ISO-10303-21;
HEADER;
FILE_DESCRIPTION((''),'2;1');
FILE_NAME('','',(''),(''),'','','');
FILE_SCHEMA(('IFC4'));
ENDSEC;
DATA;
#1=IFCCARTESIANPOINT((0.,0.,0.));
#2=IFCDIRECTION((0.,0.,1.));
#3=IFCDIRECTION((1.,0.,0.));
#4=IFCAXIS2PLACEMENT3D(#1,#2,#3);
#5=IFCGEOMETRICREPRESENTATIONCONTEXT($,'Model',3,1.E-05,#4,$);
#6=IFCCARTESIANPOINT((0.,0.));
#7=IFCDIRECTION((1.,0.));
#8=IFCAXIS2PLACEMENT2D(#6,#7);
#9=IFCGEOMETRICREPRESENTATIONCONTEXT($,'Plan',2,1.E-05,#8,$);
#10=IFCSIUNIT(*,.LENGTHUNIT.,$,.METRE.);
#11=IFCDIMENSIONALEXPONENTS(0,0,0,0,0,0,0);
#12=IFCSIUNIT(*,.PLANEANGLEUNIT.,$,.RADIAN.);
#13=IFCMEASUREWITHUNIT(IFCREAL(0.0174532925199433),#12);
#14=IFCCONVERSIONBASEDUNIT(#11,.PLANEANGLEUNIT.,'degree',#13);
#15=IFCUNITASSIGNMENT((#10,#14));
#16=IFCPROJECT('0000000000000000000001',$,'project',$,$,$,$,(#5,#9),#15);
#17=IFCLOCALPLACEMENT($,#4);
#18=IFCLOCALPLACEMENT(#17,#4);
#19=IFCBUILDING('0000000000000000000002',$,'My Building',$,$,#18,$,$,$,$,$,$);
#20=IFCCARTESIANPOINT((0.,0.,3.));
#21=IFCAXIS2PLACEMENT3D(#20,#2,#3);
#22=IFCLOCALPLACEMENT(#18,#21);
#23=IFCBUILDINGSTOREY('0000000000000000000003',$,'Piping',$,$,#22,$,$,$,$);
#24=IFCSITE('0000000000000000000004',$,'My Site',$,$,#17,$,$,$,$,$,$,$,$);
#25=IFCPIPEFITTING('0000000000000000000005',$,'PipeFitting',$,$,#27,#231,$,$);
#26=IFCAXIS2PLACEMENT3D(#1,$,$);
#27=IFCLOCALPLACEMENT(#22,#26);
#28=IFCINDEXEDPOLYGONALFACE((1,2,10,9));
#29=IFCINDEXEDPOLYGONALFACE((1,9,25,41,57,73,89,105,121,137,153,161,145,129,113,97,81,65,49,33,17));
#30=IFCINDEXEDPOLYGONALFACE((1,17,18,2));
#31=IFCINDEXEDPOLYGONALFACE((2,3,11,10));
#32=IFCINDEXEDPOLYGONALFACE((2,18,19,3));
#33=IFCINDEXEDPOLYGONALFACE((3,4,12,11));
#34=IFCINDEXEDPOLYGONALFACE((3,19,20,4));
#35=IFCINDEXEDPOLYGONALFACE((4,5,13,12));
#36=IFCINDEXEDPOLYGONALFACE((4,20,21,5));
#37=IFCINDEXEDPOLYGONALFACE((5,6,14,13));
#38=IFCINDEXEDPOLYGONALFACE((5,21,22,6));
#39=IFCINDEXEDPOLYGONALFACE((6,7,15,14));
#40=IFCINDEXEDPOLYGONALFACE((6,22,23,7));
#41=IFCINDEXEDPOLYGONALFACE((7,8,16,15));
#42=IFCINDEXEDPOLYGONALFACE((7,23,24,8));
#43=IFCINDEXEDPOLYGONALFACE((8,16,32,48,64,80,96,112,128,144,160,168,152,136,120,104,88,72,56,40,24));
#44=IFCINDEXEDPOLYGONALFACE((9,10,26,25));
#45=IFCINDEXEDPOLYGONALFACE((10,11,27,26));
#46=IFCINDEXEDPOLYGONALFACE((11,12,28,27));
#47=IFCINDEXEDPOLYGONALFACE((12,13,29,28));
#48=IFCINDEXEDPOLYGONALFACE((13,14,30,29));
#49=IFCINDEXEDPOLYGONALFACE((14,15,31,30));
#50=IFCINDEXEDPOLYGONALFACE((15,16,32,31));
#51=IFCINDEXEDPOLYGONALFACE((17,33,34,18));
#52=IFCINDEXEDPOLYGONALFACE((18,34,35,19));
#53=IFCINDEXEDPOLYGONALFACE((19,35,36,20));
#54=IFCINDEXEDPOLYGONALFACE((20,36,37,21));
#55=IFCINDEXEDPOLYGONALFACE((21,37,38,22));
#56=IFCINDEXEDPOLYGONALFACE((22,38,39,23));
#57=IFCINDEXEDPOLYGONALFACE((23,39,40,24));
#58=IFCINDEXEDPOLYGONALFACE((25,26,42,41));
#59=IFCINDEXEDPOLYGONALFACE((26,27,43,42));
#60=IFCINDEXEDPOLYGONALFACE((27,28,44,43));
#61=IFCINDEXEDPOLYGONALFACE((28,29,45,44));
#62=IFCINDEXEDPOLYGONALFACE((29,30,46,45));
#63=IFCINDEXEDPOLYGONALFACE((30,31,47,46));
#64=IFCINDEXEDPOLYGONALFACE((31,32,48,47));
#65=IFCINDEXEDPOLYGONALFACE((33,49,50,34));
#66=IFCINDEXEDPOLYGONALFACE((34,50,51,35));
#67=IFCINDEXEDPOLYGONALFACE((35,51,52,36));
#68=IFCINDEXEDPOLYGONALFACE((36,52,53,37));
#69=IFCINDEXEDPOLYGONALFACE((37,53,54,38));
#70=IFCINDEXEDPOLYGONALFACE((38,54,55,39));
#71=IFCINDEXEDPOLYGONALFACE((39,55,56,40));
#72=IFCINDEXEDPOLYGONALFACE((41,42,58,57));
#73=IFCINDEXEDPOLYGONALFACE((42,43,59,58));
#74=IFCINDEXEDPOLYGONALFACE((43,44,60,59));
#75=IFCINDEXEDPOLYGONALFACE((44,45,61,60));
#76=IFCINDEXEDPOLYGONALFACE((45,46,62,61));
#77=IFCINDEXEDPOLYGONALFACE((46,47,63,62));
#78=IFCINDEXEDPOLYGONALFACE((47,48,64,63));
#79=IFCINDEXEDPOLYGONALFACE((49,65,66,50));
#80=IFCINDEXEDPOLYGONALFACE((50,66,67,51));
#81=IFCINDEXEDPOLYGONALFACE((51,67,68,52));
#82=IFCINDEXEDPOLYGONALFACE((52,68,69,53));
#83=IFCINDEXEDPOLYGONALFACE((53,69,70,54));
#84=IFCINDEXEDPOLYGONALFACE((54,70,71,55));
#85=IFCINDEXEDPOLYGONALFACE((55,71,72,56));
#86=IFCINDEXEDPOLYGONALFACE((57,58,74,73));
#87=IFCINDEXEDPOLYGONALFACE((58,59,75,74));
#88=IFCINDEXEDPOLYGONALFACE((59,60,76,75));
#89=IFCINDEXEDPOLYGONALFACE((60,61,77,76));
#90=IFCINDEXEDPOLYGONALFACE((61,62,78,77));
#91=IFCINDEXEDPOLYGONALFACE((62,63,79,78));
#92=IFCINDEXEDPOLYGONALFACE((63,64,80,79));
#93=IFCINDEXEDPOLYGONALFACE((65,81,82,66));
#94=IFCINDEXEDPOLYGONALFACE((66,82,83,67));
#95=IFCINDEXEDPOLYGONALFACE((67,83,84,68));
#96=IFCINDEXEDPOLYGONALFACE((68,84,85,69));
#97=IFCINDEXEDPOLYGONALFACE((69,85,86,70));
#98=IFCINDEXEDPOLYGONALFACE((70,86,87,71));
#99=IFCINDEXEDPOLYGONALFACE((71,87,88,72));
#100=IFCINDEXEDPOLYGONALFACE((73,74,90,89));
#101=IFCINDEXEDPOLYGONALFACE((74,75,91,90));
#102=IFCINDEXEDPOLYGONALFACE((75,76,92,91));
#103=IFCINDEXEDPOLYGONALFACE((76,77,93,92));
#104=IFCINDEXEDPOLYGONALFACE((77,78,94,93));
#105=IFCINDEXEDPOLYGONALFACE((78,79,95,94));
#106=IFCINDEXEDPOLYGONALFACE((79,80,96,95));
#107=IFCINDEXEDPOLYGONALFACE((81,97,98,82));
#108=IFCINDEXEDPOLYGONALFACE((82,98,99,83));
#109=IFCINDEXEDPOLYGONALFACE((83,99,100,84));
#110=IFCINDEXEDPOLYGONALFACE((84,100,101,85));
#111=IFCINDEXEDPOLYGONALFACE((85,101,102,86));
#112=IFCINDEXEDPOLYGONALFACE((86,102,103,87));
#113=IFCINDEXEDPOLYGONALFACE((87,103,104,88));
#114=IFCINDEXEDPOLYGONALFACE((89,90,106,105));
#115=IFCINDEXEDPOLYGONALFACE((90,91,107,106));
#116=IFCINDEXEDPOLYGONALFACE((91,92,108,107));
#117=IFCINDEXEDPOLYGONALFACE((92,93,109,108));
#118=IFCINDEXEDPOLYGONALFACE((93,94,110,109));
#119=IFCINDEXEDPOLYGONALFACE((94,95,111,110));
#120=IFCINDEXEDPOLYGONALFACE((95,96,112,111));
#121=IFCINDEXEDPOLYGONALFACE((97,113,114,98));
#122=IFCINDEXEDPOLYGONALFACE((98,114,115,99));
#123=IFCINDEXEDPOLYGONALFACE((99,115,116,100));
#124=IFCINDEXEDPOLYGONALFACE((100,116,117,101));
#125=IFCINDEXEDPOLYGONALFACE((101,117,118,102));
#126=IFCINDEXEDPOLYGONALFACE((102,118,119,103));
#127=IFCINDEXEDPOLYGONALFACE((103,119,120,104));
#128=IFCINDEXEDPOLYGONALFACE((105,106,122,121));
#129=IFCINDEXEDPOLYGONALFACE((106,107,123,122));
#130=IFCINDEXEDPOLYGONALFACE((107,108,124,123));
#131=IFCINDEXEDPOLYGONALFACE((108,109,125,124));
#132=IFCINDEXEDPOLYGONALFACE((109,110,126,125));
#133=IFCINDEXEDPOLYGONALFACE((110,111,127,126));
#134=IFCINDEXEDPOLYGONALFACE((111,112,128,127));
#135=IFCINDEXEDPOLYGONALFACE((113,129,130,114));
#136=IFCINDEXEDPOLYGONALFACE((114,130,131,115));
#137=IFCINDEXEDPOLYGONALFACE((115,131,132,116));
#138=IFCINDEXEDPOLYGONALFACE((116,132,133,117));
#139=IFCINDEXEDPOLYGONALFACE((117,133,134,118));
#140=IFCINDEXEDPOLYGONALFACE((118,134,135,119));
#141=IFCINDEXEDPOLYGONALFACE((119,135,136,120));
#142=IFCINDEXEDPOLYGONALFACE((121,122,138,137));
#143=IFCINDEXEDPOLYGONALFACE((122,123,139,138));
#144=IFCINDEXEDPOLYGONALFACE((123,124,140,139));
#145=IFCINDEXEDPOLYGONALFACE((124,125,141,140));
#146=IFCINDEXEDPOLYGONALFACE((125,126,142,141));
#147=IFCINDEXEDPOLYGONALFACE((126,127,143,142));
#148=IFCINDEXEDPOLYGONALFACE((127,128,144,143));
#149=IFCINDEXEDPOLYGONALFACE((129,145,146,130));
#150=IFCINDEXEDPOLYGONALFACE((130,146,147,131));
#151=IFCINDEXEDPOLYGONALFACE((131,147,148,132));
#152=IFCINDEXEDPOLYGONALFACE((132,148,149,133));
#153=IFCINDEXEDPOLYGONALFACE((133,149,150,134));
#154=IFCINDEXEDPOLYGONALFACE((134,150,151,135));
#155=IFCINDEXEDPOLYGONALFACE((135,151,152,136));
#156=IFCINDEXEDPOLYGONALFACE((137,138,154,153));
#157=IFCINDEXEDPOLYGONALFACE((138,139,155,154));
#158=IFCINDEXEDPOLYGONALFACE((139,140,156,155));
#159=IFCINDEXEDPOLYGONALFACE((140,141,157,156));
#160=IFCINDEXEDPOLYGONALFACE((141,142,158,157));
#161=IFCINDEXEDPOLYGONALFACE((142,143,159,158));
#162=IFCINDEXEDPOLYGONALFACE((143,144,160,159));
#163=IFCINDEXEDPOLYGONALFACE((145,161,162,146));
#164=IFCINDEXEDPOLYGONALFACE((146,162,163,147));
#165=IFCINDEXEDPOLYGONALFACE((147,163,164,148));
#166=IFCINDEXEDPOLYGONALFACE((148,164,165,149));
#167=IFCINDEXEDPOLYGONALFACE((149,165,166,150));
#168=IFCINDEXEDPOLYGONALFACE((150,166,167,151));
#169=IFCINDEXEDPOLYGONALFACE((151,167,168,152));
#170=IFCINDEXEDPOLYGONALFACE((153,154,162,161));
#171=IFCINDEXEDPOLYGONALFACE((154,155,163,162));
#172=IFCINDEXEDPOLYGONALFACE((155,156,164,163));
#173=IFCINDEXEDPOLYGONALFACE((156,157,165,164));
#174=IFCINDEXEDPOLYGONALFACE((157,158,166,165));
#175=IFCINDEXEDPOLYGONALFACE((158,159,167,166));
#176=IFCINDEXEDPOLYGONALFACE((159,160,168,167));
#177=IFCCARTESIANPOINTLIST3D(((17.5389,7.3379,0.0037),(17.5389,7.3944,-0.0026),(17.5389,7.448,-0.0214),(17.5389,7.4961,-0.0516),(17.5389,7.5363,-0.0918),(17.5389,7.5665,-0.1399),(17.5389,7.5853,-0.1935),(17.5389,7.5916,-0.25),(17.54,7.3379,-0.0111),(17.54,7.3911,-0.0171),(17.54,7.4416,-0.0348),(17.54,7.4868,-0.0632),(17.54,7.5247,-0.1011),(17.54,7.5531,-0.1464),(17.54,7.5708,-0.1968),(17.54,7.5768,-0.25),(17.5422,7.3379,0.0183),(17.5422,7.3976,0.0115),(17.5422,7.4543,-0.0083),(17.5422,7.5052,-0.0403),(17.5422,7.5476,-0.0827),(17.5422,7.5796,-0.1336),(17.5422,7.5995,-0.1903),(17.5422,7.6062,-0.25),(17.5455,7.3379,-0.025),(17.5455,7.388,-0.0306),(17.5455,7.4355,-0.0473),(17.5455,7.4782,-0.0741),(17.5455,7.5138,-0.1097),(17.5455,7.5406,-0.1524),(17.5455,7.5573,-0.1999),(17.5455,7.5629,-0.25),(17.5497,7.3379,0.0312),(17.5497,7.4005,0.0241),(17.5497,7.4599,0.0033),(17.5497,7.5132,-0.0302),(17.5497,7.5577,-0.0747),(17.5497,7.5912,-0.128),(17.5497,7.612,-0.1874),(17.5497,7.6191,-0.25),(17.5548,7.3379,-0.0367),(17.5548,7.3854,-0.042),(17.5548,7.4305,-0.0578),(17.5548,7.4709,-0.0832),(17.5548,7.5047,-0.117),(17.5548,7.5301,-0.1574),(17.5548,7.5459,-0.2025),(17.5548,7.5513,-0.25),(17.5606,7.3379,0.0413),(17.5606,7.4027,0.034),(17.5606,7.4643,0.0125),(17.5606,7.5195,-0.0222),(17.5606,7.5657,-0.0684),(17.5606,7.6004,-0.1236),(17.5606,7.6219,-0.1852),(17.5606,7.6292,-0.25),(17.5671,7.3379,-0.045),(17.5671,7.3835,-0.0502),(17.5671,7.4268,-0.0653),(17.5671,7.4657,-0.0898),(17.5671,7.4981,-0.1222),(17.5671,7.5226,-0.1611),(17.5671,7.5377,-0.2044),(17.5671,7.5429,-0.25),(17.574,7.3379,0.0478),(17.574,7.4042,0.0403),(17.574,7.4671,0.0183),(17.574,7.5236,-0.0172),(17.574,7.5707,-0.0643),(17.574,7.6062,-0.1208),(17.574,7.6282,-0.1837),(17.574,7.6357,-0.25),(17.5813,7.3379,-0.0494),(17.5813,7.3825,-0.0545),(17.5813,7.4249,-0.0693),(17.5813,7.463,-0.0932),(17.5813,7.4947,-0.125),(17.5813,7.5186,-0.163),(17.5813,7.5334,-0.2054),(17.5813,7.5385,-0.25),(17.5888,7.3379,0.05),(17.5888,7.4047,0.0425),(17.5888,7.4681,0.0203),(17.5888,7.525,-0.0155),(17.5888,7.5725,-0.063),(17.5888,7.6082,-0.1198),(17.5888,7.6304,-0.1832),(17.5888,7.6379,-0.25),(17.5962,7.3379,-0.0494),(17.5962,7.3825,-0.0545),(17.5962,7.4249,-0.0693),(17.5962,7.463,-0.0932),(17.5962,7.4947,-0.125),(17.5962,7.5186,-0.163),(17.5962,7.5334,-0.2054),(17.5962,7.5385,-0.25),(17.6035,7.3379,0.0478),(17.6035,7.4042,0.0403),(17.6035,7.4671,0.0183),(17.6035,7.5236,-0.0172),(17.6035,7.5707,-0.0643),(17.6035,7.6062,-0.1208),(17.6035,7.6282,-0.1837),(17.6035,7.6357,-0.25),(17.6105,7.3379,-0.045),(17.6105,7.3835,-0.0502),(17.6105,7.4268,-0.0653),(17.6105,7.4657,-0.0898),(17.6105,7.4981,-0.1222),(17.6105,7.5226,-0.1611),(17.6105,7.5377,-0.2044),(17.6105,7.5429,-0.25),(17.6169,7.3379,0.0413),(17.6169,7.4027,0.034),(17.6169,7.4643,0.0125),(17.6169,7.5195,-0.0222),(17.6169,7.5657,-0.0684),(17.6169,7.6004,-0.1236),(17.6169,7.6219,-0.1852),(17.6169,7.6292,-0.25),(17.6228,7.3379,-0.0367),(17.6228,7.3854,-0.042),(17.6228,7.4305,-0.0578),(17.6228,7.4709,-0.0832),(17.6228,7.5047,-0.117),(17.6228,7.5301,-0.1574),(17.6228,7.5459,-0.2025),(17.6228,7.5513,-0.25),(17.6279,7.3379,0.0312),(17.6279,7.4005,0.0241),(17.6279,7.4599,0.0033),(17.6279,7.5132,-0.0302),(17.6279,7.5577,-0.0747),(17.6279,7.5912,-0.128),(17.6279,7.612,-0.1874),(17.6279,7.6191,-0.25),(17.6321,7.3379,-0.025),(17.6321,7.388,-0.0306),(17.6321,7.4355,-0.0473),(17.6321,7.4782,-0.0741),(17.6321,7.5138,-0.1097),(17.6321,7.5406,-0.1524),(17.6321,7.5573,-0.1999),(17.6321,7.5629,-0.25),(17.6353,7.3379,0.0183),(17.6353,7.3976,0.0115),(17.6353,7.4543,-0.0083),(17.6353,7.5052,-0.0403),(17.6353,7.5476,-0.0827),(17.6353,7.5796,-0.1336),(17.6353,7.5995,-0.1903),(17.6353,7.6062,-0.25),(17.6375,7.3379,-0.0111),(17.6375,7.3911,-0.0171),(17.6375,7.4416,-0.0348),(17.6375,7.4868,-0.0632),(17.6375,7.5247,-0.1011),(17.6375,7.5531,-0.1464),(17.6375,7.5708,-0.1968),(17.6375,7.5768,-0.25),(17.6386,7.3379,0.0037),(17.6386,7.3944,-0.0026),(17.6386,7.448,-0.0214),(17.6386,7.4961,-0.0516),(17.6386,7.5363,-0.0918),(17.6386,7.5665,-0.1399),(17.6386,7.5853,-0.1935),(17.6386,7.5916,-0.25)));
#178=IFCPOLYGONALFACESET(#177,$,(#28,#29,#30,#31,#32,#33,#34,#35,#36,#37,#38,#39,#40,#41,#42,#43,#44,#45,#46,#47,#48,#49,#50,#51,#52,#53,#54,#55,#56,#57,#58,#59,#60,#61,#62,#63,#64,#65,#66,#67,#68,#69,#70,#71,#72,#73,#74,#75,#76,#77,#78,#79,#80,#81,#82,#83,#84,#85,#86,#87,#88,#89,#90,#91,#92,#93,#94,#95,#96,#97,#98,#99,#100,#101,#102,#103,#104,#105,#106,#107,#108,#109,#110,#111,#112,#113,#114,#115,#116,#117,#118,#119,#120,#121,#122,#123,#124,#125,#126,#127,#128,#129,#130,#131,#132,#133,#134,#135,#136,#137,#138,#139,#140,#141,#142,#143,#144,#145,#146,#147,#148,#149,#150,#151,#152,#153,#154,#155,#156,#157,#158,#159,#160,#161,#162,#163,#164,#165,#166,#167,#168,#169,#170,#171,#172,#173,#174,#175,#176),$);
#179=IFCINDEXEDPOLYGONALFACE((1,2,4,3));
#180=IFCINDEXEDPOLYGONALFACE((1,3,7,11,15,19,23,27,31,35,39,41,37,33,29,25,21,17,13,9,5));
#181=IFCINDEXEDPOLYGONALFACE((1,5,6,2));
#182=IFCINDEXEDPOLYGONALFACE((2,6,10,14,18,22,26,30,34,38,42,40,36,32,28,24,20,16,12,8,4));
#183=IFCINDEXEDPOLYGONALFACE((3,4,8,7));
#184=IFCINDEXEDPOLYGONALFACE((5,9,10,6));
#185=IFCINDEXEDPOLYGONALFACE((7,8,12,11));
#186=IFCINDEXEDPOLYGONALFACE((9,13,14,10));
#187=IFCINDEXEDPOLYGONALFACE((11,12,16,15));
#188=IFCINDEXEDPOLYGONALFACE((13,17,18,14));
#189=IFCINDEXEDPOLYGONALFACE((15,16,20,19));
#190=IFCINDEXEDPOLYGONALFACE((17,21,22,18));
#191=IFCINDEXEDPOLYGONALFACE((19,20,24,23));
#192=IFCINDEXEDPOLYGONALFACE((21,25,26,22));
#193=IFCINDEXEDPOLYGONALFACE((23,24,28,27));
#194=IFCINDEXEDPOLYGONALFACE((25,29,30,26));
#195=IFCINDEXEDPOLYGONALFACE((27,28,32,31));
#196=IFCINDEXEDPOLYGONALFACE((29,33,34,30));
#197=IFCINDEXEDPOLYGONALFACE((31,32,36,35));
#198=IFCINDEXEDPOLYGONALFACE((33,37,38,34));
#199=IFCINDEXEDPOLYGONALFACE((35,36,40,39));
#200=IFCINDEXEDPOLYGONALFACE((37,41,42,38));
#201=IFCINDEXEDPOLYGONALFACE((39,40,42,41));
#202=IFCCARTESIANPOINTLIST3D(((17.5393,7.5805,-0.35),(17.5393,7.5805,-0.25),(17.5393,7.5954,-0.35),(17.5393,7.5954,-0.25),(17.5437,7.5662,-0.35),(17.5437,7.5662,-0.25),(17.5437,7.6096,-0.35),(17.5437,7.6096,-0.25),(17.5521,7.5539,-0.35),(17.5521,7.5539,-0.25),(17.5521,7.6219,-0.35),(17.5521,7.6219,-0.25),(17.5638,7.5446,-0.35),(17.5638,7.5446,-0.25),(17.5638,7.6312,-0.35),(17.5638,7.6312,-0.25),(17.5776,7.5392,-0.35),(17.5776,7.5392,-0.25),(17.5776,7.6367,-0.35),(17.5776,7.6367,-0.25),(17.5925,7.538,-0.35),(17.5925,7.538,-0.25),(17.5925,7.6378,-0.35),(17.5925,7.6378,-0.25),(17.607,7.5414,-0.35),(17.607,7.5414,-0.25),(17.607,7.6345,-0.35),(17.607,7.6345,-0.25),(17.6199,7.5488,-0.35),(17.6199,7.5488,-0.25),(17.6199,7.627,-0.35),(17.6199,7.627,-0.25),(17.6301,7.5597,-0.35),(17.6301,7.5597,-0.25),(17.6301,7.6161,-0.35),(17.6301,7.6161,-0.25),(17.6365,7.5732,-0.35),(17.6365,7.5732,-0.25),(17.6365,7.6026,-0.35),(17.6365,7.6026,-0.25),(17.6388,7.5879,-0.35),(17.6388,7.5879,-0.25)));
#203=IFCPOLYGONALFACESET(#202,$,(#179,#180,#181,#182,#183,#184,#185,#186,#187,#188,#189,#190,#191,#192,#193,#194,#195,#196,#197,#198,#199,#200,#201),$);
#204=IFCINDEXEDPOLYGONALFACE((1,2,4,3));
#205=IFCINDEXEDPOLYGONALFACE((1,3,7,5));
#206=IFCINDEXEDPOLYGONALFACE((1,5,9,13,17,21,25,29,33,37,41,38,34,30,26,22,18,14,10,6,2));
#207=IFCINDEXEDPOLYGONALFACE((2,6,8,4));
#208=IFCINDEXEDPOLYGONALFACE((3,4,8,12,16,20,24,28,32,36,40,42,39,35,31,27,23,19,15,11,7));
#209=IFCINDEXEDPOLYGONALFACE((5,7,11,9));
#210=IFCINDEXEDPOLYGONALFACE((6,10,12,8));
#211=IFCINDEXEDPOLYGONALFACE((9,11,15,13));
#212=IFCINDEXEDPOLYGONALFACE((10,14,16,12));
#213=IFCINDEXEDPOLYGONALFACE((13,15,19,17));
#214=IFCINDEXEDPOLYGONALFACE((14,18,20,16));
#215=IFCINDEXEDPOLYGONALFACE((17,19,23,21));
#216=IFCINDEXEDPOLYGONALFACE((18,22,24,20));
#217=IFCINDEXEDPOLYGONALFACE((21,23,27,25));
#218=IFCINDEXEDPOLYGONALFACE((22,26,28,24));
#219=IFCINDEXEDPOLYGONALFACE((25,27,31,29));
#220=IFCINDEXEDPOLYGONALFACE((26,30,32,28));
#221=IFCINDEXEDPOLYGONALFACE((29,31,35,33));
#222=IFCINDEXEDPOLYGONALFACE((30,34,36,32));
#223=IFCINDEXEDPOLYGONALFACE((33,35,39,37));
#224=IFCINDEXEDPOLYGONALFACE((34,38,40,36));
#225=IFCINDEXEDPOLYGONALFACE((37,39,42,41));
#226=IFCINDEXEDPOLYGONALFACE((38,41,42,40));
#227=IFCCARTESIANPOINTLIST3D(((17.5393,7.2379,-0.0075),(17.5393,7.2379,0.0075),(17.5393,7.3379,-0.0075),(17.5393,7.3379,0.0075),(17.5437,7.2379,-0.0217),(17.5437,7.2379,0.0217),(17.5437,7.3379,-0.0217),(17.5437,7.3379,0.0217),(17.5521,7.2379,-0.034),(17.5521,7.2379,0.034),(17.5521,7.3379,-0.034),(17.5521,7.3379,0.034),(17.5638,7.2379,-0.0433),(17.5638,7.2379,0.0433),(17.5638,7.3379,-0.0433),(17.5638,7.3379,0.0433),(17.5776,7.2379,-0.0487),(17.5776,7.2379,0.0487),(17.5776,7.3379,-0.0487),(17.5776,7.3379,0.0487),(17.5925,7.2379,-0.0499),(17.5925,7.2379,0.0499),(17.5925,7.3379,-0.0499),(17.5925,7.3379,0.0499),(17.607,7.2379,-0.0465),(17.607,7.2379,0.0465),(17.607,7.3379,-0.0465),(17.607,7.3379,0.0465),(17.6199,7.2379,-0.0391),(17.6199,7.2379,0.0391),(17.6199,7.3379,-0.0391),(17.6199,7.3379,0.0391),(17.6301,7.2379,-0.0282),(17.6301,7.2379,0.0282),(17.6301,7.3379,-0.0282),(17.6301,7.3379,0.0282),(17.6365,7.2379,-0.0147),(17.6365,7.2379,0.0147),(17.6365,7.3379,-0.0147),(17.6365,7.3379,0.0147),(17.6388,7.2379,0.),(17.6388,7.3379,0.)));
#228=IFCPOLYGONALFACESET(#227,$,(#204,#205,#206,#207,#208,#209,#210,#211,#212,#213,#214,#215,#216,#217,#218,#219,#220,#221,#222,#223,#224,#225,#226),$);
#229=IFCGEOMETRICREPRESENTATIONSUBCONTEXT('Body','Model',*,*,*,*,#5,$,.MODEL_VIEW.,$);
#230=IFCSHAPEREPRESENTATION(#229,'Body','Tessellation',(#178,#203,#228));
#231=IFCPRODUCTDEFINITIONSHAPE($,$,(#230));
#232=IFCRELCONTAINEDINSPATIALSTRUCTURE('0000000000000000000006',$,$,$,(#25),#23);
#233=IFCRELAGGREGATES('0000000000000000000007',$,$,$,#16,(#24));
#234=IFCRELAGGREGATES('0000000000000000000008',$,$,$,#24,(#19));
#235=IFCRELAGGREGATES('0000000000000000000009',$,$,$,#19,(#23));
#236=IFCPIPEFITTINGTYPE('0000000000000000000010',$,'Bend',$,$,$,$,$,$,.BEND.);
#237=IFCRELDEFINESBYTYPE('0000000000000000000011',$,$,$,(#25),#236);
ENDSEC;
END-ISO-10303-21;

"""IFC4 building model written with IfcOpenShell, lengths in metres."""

from ifc_helpers import new_model, entity, si_unit, converted_unit, frame, origin_with_axes, origin_2d_with_axis, place, context, subcontext, project, spatial, line, indexed_curve, circle, outline, extrude, source, transform, mapped, type_object, type_shapes, element, save


model = new_model("IFC4")

# Units and contexts
model_context = context("Model", 3, precision=1e-05, world=origin_with_axes())
plan_context = context("Plan", 2, precision=1e-05, world=origin_2d_with_axis())
body_context = subcontext(model_context, "Body", "Model", "MODEL_VIEW")
ifc_project = project(units=[si_unit("LENGTHUNIT", "METRE"), converted_unit("PLANEANGLEUNIT", "degree", entity("IfcReal", 0.0174532925199433), si_unit("PLANEANGLEUNIT", "RADIAN"), dimensions=[0, 0, 0, 0, 0, 0, 0])], contexts=[model_context, plan_context])

# Site, building, storey
site_placement = place(None, origin_with_axes())
site = spatial("IfcSite", under=ifc_project, at=site_placement, Name="My Site")
building_placement = place(site_placement, origin_with_axes())
building = spatial("IfcBuilding", under=site, at=building_placement, Name="My Building")
storey_placement = place(building_placement, frame((0.0, 0.0, 3.0), z_axis=(0.0, 0.0, 1.0), x_axis=(1.0, 0.0, 0.0)))
storey = spatial("IfcBuildingStorey", under=building, at=storey_placement, Name="Piping")

# Pipe fitting, opening
pipe_fitting_type = type_object("IfcPipeFittingType", Name="Bend", PredefinedType="BEND")
shared_shape = source(origin_with_axes(), body_context, "Body", "SolidModel", [
    entity("IfcSweptDiskSolid", entity("IfcIndexedPolyCurve", entity("IfcCartesianPointList3D", [[0.0, 0.0, -0.1], [0.0, 0.0732, -0.2768], [0.0, 0.25, -0.35]]), [entity("IfcArcIndex", [1, 2, 3])]), 0.05),
    extrude(circle(Radius=0.05), origin_with_axes(), (0.0, 0.0, -1.0), 0.1),
    extrude(circle(Radius=0.05), frame((0.0, 0.25, -0.35), z_axis=(0.0, 1.0, 0.0), x_axis=(1.0, 0.0, 0.0)), (0.0, 0.0, 1.0), 0.1),
])
type_shapes(pipe_fitting_type, [shared_shape])
pipe_fitting_1_placement = place(storey_placement, frame((17.5888, 7.5879, -0.35), z_axis=(0.0, 0.0, -1.0), x_axis=(1.0, 0.0, 0.0)))
pipe_fitting_1 = element("IfcPipeFitting", 1, at=pipe_fitting_1_placement, inside=storey, type_object=pipe_fitting_type, Name="PipeFitting", context=body_context, shape_type="MappedRepresentation", body=[
    mapped(shared_shape, transform((0.0, 0.0, 0.0), x_axis=(1.0, 0.0, 0.0), y_axis=(0.0, 1.0, 0.0), z_axis=(0.0, 0.0, 1.0), scale=1.0)),
])
opening_1_placement = place(pipe_fitting_1_placement, frame((1.9673, -1.5235, 2.65), z_axis=(0.0, 0.0, -1.0), x_axis=(-1.0, 0.0, 0.0)))
element("IfcOpeningElement", 2, at=opening_1_placement, cuts=pipe_fitting_1, PredefinedType="OPENING", context=body_context, shape_type="SweptSolid", body=[
    extrude(outline(indexed_curve([(0.0, 0.0), (0.5, 0.0), (0.5, 0.5), (0.0, 0.5)], segments=[line(1, 2, 3, 4, 1)])), origin_with_axes(), (0.0, 0.0, 1.0), 0.5),
])

save(model, "model.ifc")
